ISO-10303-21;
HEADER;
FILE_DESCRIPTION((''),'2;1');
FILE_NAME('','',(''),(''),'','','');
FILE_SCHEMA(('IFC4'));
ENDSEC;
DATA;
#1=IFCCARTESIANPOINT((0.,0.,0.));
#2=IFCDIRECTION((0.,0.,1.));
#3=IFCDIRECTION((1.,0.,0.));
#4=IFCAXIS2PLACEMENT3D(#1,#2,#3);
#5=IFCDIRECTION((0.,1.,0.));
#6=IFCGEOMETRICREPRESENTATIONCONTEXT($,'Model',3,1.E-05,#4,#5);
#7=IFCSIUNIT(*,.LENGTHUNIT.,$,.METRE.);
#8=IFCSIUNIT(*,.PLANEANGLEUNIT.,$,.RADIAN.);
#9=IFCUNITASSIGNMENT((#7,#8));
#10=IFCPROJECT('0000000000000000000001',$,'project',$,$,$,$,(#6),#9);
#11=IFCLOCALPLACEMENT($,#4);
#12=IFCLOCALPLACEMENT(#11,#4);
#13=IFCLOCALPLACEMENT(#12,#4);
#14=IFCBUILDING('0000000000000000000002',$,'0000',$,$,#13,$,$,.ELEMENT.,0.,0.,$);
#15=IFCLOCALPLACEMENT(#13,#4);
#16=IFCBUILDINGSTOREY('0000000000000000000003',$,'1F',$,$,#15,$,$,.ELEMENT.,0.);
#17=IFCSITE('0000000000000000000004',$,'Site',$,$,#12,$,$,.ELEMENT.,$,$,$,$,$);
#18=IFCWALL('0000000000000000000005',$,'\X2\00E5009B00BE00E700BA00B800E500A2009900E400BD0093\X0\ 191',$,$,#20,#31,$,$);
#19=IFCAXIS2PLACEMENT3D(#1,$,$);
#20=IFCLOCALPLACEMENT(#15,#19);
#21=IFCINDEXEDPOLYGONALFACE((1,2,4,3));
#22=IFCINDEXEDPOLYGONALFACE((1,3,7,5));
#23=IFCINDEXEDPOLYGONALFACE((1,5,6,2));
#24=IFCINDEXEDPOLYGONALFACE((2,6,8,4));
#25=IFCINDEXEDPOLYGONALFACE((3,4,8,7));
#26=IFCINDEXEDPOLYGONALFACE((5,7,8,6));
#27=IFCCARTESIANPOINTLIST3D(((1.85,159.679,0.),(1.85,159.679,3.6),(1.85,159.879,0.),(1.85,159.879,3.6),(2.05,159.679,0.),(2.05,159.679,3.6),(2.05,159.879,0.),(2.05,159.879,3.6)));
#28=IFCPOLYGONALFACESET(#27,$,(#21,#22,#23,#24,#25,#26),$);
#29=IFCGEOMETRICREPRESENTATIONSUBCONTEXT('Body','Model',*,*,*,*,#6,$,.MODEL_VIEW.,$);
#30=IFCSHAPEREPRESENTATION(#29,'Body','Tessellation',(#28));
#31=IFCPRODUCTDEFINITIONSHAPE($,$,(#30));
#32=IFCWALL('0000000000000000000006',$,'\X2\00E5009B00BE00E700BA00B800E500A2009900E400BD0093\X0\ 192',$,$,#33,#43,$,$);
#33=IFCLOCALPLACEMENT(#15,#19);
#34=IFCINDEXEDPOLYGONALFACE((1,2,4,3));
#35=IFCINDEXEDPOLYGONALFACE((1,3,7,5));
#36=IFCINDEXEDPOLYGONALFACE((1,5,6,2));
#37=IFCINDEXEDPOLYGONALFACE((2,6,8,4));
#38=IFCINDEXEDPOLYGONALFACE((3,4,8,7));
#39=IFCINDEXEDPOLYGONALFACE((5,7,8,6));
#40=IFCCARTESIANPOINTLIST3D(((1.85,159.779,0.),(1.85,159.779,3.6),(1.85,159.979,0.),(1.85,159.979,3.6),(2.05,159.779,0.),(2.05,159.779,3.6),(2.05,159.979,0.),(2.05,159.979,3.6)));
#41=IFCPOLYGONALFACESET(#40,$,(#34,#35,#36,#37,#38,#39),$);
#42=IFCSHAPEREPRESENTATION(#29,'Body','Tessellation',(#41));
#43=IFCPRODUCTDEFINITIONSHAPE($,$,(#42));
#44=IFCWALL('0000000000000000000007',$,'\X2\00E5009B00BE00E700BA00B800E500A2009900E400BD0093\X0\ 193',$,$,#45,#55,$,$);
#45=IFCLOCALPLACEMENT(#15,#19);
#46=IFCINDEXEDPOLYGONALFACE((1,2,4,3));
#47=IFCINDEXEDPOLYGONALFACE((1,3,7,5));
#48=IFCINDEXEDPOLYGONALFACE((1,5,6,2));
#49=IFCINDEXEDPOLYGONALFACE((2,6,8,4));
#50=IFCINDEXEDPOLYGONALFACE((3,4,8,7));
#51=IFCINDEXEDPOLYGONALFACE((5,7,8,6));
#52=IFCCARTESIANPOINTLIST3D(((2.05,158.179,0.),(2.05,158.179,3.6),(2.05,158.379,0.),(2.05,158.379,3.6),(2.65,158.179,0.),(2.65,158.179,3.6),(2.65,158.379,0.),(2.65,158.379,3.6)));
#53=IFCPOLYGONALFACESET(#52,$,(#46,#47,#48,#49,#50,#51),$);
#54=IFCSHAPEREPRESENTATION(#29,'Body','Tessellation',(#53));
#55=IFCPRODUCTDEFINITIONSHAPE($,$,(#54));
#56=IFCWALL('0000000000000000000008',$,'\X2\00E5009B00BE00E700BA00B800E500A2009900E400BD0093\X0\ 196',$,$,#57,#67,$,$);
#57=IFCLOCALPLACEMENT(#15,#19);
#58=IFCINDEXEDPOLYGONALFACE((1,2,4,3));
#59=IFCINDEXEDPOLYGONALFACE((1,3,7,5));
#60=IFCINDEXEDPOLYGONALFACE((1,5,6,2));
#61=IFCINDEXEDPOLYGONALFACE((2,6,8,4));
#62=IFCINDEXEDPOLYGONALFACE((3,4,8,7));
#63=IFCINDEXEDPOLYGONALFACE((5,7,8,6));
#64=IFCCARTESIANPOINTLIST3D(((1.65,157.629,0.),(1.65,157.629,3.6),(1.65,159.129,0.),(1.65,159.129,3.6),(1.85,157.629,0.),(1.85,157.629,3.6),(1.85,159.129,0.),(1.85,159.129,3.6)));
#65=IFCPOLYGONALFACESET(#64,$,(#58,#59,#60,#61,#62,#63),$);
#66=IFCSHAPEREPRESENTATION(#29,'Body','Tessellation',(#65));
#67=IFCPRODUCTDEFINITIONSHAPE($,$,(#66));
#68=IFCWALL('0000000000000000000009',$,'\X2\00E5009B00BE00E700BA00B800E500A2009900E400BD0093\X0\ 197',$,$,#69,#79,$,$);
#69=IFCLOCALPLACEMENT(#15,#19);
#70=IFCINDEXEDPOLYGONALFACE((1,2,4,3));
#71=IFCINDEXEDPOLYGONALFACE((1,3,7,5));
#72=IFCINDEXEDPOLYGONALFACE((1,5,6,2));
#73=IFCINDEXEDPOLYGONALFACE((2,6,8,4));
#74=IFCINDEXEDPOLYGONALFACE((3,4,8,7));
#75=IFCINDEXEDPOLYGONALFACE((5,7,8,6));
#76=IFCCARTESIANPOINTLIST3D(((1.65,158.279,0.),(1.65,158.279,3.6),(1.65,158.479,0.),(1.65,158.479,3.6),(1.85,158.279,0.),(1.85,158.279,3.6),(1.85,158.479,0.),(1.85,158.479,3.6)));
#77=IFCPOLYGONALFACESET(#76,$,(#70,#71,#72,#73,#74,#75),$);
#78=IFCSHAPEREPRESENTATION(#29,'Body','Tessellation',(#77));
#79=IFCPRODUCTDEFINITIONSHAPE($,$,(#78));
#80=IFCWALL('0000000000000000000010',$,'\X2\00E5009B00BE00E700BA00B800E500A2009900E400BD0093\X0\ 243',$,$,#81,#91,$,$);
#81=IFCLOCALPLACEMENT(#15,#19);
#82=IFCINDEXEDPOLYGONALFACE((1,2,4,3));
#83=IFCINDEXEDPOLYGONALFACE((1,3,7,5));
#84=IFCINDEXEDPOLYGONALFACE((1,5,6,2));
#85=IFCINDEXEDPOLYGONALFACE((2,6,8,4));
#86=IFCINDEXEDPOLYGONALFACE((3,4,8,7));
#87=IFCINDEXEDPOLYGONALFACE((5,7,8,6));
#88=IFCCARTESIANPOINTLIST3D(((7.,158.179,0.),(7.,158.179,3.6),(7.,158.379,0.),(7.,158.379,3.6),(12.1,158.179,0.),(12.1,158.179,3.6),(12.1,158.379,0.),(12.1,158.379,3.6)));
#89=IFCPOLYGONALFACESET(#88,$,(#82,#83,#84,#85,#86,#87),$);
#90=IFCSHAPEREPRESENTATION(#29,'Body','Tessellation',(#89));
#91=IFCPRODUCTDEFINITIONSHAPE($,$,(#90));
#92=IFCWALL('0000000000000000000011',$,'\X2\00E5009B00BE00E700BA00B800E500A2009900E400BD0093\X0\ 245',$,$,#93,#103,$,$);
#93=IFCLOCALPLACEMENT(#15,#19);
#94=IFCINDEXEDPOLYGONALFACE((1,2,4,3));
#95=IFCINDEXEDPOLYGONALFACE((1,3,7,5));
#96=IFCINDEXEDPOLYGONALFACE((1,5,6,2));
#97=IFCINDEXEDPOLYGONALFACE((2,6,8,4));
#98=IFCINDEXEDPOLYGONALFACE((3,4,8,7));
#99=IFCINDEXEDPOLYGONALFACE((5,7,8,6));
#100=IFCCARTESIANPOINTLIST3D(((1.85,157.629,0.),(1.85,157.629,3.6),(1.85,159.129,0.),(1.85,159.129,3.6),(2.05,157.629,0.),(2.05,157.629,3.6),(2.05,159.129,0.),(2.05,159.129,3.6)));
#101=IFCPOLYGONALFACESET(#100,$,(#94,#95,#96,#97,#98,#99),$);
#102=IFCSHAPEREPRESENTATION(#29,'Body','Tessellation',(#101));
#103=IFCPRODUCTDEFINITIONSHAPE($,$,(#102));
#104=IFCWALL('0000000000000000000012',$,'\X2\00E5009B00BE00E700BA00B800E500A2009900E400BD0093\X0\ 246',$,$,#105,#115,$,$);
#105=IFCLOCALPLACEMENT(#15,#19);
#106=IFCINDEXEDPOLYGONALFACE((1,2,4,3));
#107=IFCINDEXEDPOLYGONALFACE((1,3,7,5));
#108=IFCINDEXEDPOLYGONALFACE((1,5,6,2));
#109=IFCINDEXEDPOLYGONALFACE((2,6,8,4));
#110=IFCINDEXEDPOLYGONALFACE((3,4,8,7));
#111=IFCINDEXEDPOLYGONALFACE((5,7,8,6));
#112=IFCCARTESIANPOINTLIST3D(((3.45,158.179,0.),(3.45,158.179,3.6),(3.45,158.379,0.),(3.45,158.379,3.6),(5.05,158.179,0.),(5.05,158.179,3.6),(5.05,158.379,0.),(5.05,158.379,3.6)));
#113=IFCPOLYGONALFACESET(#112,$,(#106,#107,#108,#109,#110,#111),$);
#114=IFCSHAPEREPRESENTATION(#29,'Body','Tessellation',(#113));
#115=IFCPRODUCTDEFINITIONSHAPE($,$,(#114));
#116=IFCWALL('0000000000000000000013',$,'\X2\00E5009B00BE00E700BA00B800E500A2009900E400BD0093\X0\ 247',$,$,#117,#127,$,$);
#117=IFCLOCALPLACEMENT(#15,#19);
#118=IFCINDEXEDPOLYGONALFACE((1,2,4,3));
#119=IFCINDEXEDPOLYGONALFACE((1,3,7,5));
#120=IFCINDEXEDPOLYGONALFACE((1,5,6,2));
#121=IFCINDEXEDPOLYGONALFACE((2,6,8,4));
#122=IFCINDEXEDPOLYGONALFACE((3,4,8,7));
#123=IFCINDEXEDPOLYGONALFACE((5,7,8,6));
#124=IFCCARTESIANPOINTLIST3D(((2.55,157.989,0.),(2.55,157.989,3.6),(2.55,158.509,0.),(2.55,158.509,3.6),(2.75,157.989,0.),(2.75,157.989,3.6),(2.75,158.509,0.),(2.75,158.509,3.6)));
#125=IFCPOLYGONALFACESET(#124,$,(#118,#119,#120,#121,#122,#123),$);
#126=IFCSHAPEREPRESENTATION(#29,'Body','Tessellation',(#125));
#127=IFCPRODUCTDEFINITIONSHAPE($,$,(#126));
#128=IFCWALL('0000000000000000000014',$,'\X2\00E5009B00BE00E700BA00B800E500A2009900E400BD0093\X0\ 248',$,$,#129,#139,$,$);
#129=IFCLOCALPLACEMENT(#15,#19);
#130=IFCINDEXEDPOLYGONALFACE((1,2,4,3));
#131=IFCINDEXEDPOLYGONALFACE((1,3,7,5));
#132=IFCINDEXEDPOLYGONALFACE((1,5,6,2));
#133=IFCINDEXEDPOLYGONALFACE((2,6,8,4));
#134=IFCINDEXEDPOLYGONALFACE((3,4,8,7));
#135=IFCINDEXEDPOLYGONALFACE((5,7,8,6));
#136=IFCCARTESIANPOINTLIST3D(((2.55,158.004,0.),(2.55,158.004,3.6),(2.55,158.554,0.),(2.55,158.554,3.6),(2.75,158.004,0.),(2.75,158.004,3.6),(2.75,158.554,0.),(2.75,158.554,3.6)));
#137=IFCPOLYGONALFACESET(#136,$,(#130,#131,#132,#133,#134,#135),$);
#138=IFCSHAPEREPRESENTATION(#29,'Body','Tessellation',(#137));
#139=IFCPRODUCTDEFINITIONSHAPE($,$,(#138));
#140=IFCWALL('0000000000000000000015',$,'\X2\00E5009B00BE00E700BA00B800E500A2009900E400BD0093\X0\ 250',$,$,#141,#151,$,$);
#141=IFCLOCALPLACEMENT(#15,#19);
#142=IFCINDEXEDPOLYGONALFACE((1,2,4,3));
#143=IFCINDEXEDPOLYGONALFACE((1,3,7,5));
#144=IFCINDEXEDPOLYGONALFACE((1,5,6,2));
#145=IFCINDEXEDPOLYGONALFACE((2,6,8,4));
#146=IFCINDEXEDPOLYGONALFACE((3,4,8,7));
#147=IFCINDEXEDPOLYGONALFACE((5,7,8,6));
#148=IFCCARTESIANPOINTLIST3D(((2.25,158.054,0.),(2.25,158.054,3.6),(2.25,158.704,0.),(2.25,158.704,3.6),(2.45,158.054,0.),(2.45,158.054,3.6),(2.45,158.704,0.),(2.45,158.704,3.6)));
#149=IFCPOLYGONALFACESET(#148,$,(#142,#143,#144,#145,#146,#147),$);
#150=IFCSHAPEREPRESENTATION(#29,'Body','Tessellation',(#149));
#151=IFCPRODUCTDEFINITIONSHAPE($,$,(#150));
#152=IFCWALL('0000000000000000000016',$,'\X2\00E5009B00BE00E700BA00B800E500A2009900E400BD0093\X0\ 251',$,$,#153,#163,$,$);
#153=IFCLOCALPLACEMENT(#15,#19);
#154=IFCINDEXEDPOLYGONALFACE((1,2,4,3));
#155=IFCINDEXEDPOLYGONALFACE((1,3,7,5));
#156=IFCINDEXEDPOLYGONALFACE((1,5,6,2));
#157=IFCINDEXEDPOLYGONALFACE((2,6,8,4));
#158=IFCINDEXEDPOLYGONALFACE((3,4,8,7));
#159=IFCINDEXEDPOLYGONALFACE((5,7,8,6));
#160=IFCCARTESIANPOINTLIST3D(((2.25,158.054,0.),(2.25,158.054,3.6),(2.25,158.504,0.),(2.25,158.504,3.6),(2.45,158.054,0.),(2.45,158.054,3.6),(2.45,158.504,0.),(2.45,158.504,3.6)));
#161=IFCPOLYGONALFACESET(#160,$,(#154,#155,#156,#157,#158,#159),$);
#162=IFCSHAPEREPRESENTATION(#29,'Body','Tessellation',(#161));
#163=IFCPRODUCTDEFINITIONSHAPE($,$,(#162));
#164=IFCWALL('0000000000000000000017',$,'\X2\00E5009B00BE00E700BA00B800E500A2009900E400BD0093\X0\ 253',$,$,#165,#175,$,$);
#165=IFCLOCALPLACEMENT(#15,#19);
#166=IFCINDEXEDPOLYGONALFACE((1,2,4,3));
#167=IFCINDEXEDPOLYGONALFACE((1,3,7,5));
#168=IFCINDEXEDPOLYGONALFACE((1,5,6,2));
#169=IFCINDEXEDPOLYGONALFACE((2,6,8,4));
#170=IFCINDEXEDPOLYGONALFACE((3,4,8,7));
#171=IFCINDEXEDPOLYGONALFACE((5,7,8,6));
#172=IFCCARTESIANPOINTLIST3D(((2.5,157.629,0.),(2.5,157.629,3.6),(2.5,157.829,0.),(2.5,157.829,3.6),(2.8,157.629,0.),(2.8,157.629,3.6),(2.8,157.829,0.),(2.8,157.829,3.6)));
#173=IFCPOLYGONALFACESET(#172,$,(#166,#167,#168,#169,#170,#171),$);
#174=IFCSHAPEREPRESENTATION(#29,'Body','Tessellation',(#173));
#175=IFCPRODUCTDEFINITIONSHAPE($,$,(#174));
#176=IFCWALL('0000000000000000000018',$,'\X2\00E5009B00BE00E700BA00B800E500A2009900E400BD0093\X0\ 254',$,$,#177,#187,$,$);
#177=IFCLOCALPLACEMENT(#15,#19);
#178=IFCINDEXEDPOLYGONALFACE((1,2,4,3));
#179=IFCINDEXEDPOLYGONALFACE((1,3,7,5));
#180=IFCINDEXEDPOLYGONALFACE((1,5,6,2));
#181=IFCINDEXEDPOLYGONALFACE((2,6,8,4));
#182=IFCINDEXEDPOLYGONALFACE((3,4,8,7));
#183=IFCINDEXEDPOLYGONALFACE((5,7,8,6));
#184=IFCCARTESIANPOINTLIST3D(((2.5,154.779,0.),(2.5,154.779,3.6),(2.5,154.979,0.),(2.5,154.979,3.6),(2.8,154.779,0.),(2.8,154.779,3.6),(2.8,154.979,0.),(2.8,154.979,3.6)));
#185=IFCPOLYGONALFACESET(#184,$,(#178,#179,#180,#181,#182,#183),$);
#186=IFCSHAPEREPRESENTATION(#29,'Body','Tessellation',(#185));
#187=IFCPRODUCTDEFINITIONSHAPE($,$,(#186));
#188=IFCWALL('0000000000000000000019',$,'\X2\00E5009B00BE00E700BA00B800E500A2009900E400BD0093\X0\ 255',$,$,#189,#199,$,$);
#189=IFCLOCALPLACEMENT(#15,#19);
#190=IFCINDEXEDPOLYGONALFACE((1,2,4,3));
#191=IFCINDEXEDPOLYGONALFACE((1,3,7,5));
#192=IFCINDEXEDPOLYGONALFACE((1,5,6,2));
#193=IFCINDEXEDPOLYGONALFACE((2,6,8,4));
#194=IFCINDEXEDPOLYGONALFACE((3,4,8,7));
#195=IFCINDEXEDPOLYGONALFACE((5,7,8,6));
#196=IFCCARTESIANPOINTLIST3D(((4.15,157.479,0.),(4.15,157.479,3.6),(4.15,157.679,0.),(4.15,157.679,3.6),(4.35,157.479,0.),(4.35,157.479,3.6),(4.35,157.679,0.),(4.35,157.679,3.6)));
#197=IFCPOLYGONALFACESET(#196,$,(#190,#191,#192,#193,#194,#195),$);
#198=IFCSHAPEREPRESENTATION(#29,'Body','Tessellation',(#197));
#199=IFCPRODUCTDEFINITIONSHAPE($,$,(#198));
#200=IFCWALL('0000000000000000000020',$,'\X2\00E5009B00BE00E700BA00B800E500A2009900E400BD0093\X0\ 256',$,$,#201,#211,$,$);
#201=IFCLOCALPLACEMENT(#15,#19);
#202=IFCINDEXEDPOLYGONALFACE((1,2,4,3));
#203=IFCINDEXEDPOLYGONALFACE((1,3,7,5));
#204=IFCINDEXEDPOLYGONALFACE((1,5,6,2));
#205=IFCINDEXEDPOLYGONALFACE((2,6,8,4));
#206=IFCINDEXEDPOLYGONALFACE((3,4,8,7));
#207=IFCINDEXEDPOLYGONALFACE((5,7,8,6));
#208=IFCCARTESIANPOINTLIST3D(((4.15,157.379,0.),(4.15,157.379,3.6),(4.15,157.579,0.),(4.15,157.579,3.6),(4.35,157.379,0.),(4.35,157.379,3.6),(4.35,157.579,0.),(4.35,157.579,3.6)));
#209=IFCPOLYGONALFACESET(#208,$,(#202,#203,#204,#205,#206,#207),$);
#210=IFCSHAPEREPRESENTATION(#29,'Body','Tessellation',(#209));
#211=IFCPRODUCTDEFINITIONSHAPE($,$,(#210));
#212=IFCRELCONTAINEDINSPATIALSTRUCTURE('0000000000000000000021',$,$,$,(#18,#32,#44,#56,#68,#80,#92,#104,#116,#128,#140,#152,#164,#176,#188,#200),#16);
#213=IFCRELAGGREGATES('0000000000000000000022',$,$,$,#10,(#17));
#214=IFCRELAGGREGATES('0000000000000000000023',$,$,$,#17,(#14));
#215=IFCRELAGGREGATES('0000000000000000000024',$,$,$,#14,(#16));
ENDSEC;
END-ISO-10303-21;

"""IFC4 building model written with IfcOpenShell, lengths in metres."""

from ifc_helpers import new_model, si_unit, direction, frame, frame_2d, origin_with_axes, place, context, subcontext, project, spatial, rectangle, extrude, element, save


model = new_model("IFC4")

# Units and contexts
model_context = context("Model", 3, precision=1e-05, world=origin_with_axes(), true_north=direction((0.0, 1.0, 0.0)))
body_context = subcontext(model_context, "Body", "Model", "MODEL_VIEW")
ifc_project = project(units=[si_unit("LENGTHUNIT", "METRE"), si_unit("PLANEANGLEUNIT", "RADIAN")], contexts=[model_context])

# Site, building, storey
placement = place(None, origin_with_axes())
site_placement = place(placement, origin_with_axes())
site = spatial("IfcSite", under=ifc_project, at=site_placement, Name="Site", CompositionType="ELEMENT")
building_placement = place(site_placement, origin_with_axes())
building = spatial("IfcBuilding", under=site, at=building_placement, Name="0000", CompositionType="ELEMENT", ElevationOfRefHeight=0.0, ElevationOfTerrain=0.0)
storey_placement = place(building_placement, origin_with_axes())
storey = spatial("IfcBuildingStorey", under=building, at=storey_placement, Name="1F", CompositionType="ELEMENT", Elevation=0.0)

# Walls
for number, where, z_axis, x_axis, name in (
    (1, (1.95, 159.779, 0.0), (0.0, 0.0, 1.0), (-1.0, 0.0, 0.0), "å\u009b¾çº¸å¢\u0099ä½\u0093 191"),
    (2, (1.95, 159.879, 0.0), (0.0, 0.0, 1.0), (-1.0, 0.0, 0.0), "å\u009b¾çº¸å¢\u0099ä½\u0093 192"),
):
    element("IfcWall", number, at=place(storey_placement, frame(where, z_axis=z_axis, x_axis=x_axis)), inside=storey, Name=name, context=body_context, shape_type="SweptSolid", body=[
        extrude(rectangle(XDim=0.2, YDim=0.2, at=frame_2d((0.0, 0.0), x_axis=(1.0, 0.0, 0.0))), frame((0.0, 0.0, 0.0), z_axis=(0.0, 0.0, 1.0)), (0.0, 0.0, 1.0), 3.6),
    ])
wall_1_placement = place(storey_placement, frame((2.35, 158.279, 0.0), z_axis=(0.0, 0.0, 1.0), x_axis=(-1.0, 0.0, 0.0)))
element("IfcWall", 3, at=wall_1_placement, inside=storey, Name="å\u009b¾çº¸å¢\u0099ä½\u0093 193", context=body_context, shape_type="SweptSolid", body=[
    extrude(rectangle(XDim=0.6, YDim=0.2, at=frame_2d((0.0, 0.0), x_axis=(1.0, 0.0, 0.0))), frame((0.0, 0.0, 0.0), z_axis=(0.0, 0.0, 1.0)), (0.0, 0.0, 1.0), 3.6),
])
wall_2_placement = place(storey_placement, frame((1.75, 158.379, 0.0), z_axis=(0.0, 0.0, 1.0), x_axis=(0.0, 1.0, 0.0)))
element("IfcWall", 4, at=wall_2_placement, inside=storey, Name="å\u009b¾çº¸å¢\u0099ä½\u0093 196", context=body_context, shape_type="SweptSolid", body=[
    extrude(rectangle(XDim=1.5, YDim=0.2, at=frame_2d((0.0, 0.0), x_axis=(1.0, 0.0, 0.0))), frame((0.0, 0.0, 0.0), z_axis=(0.0, 0.0, 1.0)), (0.0, 0.0, 1.0), 3.6),
])
wall_3_placement = place(storey_placement, frame((1.75, 158.379, 0.0), z_axis=(0.0, 0.0, 1.0), x_axis=(0.0, -1.0, 0.0)))
element("IfcWall", 5, at=wall_3_placement, inside=storey, Name="å\u009b¾çº¸å¢\u0099ä½\u0093 197", context=body_context, shape_type="SweptSolid", body=[
    extrude(rectangle(XDim=0.2, YDim=0.2, at=frame_2d((0.0, 0.0), x_axis=(1.0, 0.0, 0.0))), frame((0.0, 0.0, 0.0), z_axis=(0.0, 0.0, 1.0)), (0.0, 0.0, 1.0), 3.6),
])
wall_4_placement = place(storey_placement, frame((9.55, 158.279, 0.0), z_axis=(0.0, 0.0, 1.0), x_axis=(-1.0, 0.0, 0.0)))
element("IfcWall", 6, at=wall_4_placement, inside=storey, Name="å\u009b¾çº¸å¢\u0099ä½\u0093 243", context=body_context, shape_type="SweptSolid", body=[
    extrude(rectangle(XDim=5.1, YDim=0.2, at=frame_2d((0.0, 0.0), x_axis=(1.0, 0.0, 0.0))), frame((0.0, 0.0, 0.0), z_axis=(0.0, 0.0, 1.0)), (0.0, 0.0, 1.0), 3.6),
])
wall_5_placement = place(storey_placement, frame((1.95, 158.379, 0.0), z_axis=(0.0, 0.0, 1.0), x_axis=(0.0, 1.0, 0.0)))
element("IfcWall", 7, at=wall_5_placement, inside=storey, Name="å\u009b¾çº¸å¢\u0099ä½\u0093 245", context=body_context, shape_type="SweptSolid", body=[
    extrude(rectangle(XDim=1.5, YDim=0.2, at=frame_2d((0.0, 0.0), x_axis=(1.0, 0.0, 0.0))), frame((0.0, 0.0, 0.0), z_axis=(0.0, 0.0, 1.0)), (0.0, 0.0, 1.0), 3.6),
])
wall_6_placement = place(storey_placement, frame((4.25, 158.279, 0.0), z_axis=(0.0, 0.0, 1.0), x_axis=(-1.0, 0.0, 0.0)))
element("IfcWall", 8, at=wall_6_placement, inside=storey, Name="å\u009b¾çº¸å¢\u0099ä½\u0093 246", context=body_context, shape_type="SweptSolid", body=[
    extrude(rectangle(XDim=1.6, YDim=0.2, at=frame_2d((0.0, 0.0), x_axis=(1.0, 0.0, 0.0))), frame((0.0, 0.0, 0.0), z_axis=(0.0, 0.0, 1.0)), (0.0, 0.0, 1.0), 3.6),
])
wall_7_placement = place(storey_placement, frame((2.65, 158.249, 0.0), z_axis=(0.0, 0.0, 1.0), x_axis=(0.0, -1.0, 0.0)))
element("IfcWall", 9, at=wall_7_placement, inside=storey, Name="å\u009b¾çº¸å¢\u0099ä½\u0093 247", context=body_context, shape_type="SweptSolid", body=[
    extrude(rectangle(XDim=0.52, YDim=0.2, at=frame_2d((0.0, 0.0), x_axis=(1.0, 0.0, 0.0))), frame((0.0, 0.0, 0.0), z_axis=(0.0, 0.0, 1.0)), (0.0, 0.0, 1.0), 3.6),
])
wall_8_placement = place(storey_placement, frame((2.65, 158.279, 0.0), z_axis=(0.0, 0.0, 1.0), x_axis=(0.0, -1.0, 0.0)))
element("IfcWall", 10, at=wall_8_placement, inside=storey, Name="å\u009b¾çº¸å¢\u0099ä½\u0093 248", context=body_context, shape_type="SweptSolid", body=[
    extrude(rectangle(XDim=0.55, YDim=0.2, at=frame_2d((0.0, 0.0), x_axis=(1.0, 0.0, 0.0))), frame((0.0, 0.0, 0.0), z_axis=(0.0, 0.0, 1.0)), (0.0, 0.0, 1.0), 3.6),
])
wall_9_placement = place(storey_placement, frame((2.35, 158.379, 0.0), z_axis=(0.0, 0.0, 1.0), x_axis=(0.0, -1.0, 0.0)))
element("IfcWall", 11, at=wall_9_placement, inside=storey, Name="å\u009b¾çº¸å¢\u0099ä½\u0093 250", context=body_context, shape_type="SweptSolid", body=[
    extrude(rectangle(XDim=0.65, YDim=0.2, at=frame_2d((0.0, 0.0), x_axis=(1.0, 0.0, 0.0))), frame((0.0, 0.0, 0.0), z_axis=(0.0, 0.0, 1.0)), (0.0, 0.0, 1.0), 3.6),
])
wall_10_placement = place(storey_placement, frame((2.35, 158.279, 0.0), z_axis=(0.0, 0.0, 1.0), x_axis=(0.0, -1.0, 0.0)))
element("IfcWall", 12, at=wall_10_placement, inside=storey, Name="å\u009b¾çº¸å¢\u0099ä½\u0093 251", context=body_context, shape_type="SweptSolid", body=[
    extrude(rectangle(XDim=0.45, YDim=0.2, at=frame_2d((0.0, 0.0), x_axis=(1.0, 0.0, 0.0))), frame((0.0, 0.0, 0.0), z_axis=(0.0, 0.0, 1.0)), (0.0, 0.0, 1.0), 3.6),
])
for number, where, z_axis, x_axis, name in (
    (13, (2.65, 157.729, 0.0), (0.0, 0.0, 1.0), (-1.0, 0.0, 0.0), "å\u009b¾çº¸å¢\u0099ä½\u0093 253"),
    (14, (2.65, 154.879, 0.0), (0.0, 0.0, 1.0), (-1.0, 0.0, 0.0), "å\u009b¾çº¸å¢\u0099ä½\u0093 254"),
):
    element("IfcWall", number, at=place(storey_placement, frame(where, z_axis=z_axis, x_axis=x_axis)), inside=storey, Name=name, context=body_context, shape_type="SweptSolid", body=[
        extrude(rectangle(XDim=0.3, YDim=0.2, at=frame_2d((0.0, 0.0), x_axis=(1.0, 0.0, 0.0))), frame((0.0, 0.0, 0.0), z_axis=(0.0, 0.0, 1.0)), (0.0, 0.0, 1.0), 3.6),
    ])
for number, where, z_axis, x_axis, name in (
    (15, (4.25, 157.579, 0.0), (0.0, 0.0, 1.0), (1.0, 0.0, 0.0), "å\u009b¾çº¸å¢\u0099ä½\u0093 255"),
    (16, (4.25, 157.479, 0.0), (0.0, 0.0, 1.0), (1.0, 0.0, 0.0), "å\u009b¾çº¸å¢\u0099ä½\u0093 256"),
):
    element("IfcWall", number, at=place(storey_placement, frame(where, z_axis=z_axis, x_axis=x_axis)), inside=storey, Name=name, context=body_context, shape_type="SweptSolid", body=[
        extrude(rectangle(XDim=0.2, YDim=0.2, at=frame_2d((0.0, 0.0), x_axis=(1.0, 0.0, 0.0))), frame((0.0, 0.0, 0.0), z_axis=(0.0, 0.0, 1.0)), (0.0, 0.0, 1.0), 3.6),
    ])

save(model, "model.ifc")
